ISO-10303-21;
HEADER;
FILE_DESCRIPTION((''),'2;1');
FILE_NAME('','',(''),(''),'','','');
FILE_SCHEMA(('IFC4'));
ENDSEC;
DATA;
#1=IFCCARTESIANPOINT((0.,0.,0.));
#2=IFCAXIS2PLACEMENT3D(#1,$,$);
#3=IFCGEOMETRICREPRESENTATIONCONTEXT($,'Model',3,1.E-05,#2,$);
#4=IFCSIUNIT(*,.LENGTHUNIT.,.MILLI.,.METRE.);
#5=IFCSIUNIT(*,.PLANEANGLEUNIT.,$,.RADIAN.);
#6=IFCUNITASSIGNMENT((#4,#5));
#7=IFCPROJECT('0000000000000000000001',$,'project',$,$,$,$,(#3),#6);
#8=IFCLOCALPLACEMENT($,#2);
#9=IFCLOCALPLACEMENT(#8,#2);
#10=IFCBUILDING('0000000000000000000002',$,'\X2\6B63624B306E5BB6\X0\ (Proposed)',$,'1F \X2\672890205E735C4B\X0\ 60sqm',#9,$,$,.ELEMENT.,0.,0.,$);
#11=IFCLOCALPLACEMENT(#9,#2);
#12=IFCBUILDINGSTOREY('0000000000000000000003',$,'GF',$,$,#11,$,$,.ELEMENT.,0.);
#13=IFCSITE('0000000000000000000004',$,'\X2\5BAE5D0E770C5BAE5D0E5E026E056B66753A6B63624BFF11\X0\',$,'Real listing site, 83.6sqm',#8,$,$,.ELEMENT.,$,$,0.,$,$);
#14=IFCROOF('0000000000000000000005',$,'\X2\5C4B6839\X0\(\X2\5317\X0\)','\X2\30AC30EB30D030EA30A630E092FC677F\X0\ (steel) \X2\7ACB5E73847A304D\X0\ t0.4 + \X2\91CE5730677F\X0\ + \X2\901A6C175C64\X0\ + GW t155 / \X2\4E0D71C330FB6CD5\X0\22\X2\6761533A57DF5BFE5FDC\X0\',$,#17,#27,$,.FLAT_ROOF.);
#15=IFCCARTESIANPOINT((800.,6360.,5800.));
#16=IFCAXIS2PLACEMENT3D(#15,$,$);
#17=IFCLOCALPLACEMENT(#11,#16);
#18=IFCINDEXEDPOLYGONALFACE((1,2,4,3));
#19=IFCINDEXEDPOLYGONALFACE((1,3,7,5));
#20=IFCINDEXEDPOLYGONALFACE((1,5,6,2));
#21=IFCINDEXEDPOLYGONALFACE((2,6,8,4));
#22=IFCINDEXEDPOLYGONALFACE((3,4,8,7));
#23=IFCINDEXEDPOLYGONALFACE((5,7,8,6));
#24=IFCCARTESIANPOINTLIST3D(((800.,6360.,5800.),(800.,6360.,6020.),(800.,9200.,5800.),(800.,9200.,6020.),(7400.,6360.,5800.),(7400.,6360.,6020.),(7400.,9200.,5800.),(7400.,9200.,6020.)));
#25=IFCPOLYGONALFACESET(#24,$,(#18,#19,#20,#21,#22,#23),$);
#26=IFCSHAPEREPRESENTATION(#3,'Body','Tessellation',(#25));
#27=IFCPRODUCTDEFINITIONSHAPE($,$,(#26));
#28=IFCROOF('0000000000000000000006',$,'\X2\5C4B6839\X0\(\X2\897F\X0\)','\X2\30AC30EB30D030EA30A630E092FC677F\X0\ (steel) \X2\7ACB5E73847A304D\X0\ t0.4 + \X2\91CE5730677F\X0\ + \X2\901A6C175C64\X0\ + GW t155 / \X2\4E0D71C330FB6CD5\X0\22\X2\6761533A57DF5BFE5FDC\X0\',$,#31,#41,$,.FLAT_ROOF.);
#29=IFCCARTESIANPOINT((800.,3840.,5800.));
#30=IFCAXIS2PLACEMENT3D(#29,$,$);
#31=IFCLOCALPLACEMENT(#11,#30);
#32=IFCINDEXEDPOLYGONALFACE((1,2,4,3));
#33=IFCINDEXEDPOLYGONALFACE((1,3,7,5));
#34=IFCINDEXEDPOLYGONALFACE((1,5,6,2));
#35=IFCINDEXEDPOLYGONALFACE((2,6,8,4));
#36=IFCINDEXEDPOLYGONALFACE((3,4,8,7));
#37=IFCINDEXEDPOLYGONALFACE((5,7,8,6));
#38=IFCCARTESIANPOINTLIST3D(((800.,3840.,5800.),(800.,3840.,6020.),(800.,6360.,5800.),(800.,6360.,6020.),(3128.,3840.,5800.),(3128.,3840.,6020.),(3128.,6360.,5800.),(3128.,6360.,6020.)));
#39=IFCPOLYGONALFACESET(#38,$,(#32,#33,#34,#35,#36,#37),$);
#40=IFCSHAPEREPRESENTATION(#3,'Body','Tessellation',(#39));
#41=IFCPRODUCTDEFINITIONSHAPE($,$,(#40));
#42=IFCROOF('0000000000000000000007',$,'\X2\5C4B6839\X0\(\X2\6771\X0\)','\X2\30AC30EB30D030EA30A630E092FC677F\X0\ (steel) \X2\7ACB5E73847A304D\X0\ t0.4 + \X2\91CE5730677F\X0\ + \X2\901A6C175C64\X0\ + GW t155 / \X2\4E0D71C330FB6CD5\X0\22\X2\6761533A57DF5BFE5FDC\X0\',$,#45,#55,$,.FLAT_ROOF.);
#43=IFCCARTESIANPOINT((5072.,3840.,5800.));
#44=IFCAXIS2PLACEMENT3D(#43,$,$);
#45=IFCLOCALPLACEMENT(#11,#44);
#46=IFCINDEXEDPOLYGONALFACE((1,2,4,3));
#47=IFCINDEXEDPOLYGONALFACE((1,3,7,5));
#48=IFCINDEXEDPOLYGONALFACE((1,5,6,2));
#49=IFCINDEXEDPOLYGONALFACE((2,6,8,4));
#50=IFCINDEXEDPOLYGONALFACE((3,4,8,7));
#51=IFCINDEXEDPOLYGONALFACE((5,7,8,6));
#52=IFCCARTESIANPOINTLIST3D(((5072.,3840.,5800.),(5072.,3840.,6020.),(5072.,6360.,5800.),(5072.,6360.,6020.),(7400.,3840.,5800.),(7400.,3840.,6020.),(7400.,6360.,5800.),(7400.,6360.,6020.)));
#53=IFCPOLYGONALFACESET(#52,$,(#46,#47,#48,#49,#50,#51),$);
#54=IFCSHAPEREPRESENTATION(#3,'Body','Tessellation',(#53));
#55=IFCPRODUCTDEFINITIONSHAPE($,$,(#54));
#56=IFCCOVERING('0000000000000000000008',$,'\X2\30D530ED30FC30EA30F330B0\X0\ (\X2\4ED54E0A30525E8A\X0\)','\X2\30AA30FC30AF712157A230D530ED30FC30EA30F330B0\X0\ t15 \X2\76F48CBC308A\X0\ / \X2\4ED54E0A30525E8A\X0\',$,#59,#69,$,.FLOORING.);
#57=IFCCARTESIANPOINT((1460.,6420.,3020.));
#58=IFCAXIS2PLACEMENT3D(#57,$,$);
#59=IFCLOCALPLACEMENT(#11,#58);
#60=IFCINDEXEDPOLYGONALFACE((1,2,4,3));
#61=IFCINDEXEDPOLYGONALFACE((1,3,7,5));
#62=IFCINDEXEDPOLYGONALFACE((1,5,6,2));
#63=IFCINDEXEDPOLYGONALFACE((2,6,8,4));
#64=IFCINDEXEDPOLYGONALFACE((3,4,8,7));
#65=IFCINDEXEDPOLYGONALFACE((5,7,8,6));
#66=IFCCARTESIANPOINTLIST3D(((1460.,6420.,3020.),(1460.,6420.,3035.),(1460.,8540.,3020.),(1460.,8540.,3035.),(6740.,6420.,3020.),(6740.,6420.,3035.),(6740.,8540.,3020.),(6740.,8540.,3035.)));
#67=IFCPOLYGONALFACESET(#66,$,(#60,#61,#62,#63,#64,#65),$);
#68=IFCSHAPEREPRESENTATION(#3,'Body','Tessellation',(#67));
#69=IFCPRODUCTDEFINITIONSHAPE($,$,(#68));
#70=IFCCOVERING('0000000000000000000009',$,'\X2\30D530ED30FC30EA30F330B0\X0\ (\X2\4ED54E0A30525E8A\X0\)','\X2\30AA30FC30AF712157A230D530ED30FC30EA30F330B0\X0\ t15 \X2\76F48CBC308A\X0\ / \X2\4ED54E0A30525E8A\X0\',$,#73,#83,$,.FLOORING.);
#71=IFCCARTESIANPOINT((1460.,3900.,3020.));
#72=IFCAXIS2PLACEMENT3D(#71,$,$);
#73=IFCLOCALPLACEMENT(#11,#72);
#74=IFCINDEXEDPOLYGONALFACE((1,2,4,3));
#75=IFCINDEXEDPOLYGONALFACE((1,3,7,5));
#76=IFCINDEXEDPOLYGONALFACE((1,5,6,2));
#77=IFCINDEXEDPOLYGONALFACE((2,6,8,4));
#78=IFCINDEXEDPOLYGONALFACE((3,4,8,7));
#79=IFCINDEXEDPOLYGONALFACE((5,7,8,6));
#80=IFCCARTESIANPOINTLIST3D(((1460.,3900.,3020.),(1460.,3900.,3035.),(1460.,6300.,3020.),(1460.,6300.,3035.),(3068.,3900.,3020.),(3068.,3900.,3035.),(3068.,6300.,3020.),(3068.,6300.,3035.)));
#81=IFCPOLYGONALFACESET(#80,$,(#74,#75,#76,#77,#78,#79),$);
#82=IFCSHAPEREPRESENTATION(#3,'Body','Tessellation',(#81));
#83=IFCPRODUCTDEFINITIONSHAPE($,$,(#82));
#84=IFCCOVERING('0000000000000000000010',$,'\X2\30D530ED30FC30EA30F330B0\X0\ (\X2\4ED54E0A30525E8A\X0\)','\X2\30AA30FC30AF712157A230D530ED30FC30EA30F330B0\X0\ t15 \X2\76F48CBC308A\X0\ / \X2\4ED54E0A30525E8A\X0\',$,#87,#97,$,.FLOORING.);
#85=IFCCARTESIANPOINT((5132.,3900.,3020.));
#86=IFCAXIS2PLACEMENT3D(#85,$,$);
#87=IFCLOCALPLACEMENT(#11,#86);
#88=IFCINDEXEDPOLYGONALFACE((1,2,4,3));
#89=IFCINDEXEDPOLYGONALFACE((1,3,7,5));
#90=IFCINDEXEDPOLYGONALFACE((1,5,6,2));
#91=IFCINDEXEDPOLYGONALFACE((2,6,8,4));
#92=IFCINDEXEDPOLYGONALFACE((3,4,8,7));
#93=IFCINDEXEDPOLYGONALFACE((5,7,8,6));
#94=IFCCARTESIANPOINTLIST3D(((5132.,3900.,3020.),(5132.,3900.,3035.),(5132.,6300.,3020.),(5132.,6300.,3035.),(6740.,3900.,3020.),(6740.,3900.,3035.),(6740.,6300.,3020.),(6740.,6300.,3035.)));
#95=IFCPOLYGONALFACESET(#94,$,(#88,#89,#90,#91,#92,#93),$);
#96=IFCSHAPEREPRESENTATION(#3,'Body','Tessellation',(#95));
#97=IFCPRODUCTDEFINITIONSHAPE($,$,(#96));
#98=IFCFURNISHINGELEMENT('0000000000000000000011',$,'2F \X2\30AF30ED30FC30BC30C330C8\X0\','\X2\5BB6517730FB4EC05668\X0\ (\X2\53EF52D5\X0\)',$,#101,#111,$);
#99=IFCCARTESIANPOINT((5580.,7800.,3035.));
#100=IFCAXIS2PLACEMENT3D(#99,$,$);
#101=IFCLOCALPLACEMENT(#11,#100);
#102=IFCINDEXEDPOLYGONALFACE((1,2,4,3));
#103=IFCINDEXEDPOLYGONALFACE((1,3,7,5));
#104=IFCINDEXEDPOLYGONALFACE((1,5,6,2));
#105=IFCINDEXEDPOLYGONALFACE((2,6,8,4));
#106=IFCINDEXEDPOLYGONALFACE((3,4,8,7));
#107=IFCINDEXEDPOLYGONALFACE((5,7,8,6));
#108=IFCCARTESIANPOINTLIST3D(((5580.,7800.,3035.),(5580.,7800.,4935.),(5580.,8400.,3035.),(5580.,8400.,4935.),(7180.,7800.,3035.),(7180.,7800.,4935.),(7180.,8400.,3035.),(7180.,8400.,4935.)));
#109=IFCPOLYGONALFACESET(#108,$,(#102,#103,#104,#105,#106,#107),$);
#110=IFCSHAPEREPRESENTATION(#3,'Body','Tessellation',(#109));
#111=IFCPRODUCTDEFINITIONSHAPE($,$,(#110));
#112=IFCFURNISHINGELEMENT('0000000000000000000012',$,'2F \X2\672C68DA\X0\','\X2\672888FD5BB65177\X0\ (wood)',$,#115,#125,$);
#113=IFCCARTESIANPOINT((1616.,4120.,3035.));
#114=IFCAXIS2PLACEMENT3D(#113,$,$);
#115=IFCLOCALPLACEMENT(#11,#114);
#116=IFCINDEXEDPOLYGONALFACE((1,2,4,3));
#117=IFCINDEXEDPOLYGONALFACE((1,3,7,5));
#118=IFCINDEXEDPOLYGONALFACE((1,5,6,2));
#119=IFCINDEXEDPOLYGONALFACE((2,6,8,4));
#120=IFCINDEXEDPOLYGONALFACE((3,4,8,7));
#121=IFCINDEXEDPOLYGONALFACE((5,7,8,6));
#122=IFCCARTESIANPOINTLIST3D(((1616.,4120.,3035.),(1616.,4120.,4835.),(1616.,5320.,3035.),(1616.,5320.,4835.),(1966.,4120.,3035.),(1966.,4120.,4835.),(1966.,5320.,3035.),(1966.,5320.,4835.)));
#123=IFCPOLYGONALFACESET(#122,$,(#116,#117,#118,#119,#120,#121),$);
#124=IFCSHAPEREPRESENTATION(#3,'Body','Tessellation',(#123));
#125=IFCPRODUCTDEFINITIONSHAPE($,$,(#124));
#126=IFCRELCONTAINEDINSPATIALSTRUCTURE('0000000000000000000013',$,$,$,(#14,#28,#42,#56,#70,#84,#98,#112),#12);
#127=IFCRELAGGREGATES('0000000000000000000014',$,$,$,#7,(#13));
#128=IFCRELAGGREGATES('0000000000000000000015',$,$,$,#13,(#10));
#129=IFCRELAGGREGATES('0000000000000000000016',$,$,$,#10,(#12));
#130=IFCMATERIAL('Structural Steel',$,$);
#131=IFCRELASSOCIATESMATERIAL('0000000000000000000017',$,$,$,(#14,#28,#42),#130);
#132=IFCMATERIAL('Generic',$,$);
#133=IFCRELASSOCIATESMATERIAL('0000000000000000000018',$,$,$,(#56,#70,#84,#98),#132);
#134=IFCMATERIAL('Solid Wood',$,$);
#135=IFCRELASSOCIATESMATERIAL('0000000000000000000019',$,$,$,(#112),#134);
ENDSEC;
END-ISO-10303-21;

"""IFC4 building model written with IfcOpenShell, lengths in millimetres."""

from ifc_helpers import new_model, si_unit, frame, frame_2d, origin, place, context, project, spatial, rectangle, extrude, material, element, save


model = new_model("IFC4")

# Units and contexts
model_context = context("Model", 3, precision=1e-05, world=origin())
ifc_project = project(units=[si_unit("LENGTHUNIT", "METRE", prefix="MILLI"), si_unit("PLANEANGLEUNIT", "RADIAN")], contexts=[model_context])

# Site, building, storey
site_placement = place(None, origin())
site = spatial("IfcSite", under=ifc_project, at=site_placement, Name="宮崎県宮崎市清武町正手１", ObjectType="Real listing site, 83.6sqm", CompositionType="ELEMENT", RefElevation=0.0)
building_placement = place(site_placement, origin())
building = spatial("IfcBuilding", under=site, at=building_placement, Name="正手の家 (Proposed)", ObjectType="1F 木造平屋 60sqm", CompositionType="ELEMENT", ElevationOfRefHeight=0.0, ElevationOfTerrain=0.0)
storey_placement = place(building_placement, origin())
storey = spatial("IfcBuildingStorey", under=building, at=storey_placement, Name="GF", CompositionType="ELEMENT", Elevation=0.0)

# Shared definitions
ifc_material_1 = material(Name="Solid Wood")

# Shared definitions
ifc_material_2 = material(Name="Generic")

# Roofs
ifc_material_3 = material(Name="Structural Steel")
for number, where, name in (
    (1, (800.0, 6360.0, 5800.0), "屋根(北)"),
):
    element("IfcRoof", number, at=place(storey_placement, frame(where)), inside=storey, material=ifc_material_3, Name=name, Description="ガルバリウム鋼板 (steel) 立平葺き t0.4 + 野地板 + 通気層 + GW t155 / 不燃・法22条区域対応", PredefinedType="FLAT_ROOF", context=model_context, shape_type="SweptSolid", body=[
        extrude(rectangle(XDim=6600.0, YDim=2840.0, at=frame_2d((3300.0, 1420.0))), frame((800.0, 6360.0, 5800.0)), (0.0, 0.0, 1.0), 220.0),
    ])
roof_1_placement = place(storey_placement, frame((800.0, 3840.0, 5800.0)))
element("IfcRoof", 2, at=roof_1_placement, inside=storey, material=ifc_material_3, Name="屋根(西)", Description="ガルバリウム鋼板 (steel) 立平葺き t0.4 + 野地板 + 通気層 + GW t155 / 不燃・法22条区域対応", PredefinedType="FLAT_ROOF", context=model_context, shape_type="SweptSolid", body=[
    extrude(rectangle(XDim=2328.0, YDim=2520.0, at=frame_2d((1164.0, 1260.0))), frame((800.0, 3840.0, 5800.0)), (0.0, 0.0, 1.0), 220.0),
])
roof_2_placement = place(storey_placement, frame((5072.0, 3840.0, 5800.0)))
element("IfcRoof", 3, at=roof_2_placement, inside=storey, material=ifc_material_3, Name="屋根(東)", Description="ガルバリウム鋼板 (steel) 立平葺き t0.4 + 野地板 + 通気層 + GW t155 / 不燃・法22条区域対応", PredefinedType="FLAT_ROOF", context=model_context, shape_type="SweptSolid", body=[
    extrude(rectangle(XDim=2328.0, YDim=2520.0, at=frame_2d((1164.0, 1260.0))), frame((5072.0, 3840.0, 5800.0)), (0.0, 0.0, 1.0), 220.0),
])

# Coverings
covering_1_placement = place(storey_placement, frame((1460.0, 6420.0, 3020.0)))
element("IfcCovering", 4, at=covering_1_placement, inside=storey, material=ifc_material_2, Name="フローリング (仕上げ床)", Description="オーク無垢フローリング t15 直貼り / 仕上げ床", PredefinedType="FLOORING", context=model_context, shape_type="SweptSolid", body=[
    extrude(rectangle(XDim=5280.0, YDim=2120.0, at=frame_2d((2640.0, 1060.0))), frame((1460.0, 6420.0, 3020.0)), (0.0, 0.0, 1.0), 15.0),
])
covering_2_placement = place(storey_placement, frame((1460.0, 3900.0, 3020.0)))
element("IfcCovering", 5, at=covering_2_placement, inside=storey, material=ifc_material_2, Name="フローリング (仕上げ床)", Description="オーク無垢フローリング t15 直貼り / 仕上げ床", PredefinedType="FLOORING", context=model_context, shape_type="SweptSolid", body=[
    extrude(rectangle(XDim=1608.0, YDim=2400.0, at=frame_2d((804.0, 1200.0))), frame((1460.0, 3900.0, 3020.0)), (0.0, 0.0, 1.0), 15.0),
])
covering_3_placement = place(storey_placement, frame((5132.0, 3900.0, 3020.0)))
element("IfcCovering", 6, at=covering_3_placement, inside=storey, material=ifc_material_2, Name="フローリング (仕上げ床)", Description="オーク無垢フローリング t15 直貼り / 仕上げ床", PredefinedType="FLOORING", context=model_context, shape_type="SweptSolid", body=[
    extrude(rectangle(XDim=1608.0, YDim=2400.0, at=frame_2d((804.0, 1200.0))), frame((5132.0, 3900.0, 3020.0)), (0.0, 0.0, 1.0), 15.0),
])

# Furnishing elements
furnishing_1_placement = place(storey_placement, frame((5580.0, 7800.0, 3035.0)))
element("IfcFurnishingElement", 7, at=furnishing_1_placement, inside=storey, material=ifc_material_2, Name="2F クローゼット", Description="家具・什器 (可動)", context=model_context, shape_type="SweptSolid", body=[
    extrude(rectangle(XDim=1600.0, YDim=600.0, at=frame_2d((800.0, 300.0))), frame((5580.0, 7800.0, 3035.0)), (0.0, 0.0, 1.0), 1900.0),
])
furnishing_2_placement = place(storey_placement, frame((1616.0, 4120.0, 3035.0)))
element("IfcFurnishingElement", 8, at=furnishing_2_placement, inside=storey, material=ifc_material_1, Name="2F 本棚", Description="木製家具 (wood)", context=model_context, shape_type="SweptSolid", body=[
    extrude(rectangle(XDim=350.0, YDim=1200.0, at=frame_2d((175.0, 600.0))), frame((1616.0, 4120.0, 3035.0)), (0.0, 0.0, 1.0), 1800.0),
])

save(model, "model.ifc")
